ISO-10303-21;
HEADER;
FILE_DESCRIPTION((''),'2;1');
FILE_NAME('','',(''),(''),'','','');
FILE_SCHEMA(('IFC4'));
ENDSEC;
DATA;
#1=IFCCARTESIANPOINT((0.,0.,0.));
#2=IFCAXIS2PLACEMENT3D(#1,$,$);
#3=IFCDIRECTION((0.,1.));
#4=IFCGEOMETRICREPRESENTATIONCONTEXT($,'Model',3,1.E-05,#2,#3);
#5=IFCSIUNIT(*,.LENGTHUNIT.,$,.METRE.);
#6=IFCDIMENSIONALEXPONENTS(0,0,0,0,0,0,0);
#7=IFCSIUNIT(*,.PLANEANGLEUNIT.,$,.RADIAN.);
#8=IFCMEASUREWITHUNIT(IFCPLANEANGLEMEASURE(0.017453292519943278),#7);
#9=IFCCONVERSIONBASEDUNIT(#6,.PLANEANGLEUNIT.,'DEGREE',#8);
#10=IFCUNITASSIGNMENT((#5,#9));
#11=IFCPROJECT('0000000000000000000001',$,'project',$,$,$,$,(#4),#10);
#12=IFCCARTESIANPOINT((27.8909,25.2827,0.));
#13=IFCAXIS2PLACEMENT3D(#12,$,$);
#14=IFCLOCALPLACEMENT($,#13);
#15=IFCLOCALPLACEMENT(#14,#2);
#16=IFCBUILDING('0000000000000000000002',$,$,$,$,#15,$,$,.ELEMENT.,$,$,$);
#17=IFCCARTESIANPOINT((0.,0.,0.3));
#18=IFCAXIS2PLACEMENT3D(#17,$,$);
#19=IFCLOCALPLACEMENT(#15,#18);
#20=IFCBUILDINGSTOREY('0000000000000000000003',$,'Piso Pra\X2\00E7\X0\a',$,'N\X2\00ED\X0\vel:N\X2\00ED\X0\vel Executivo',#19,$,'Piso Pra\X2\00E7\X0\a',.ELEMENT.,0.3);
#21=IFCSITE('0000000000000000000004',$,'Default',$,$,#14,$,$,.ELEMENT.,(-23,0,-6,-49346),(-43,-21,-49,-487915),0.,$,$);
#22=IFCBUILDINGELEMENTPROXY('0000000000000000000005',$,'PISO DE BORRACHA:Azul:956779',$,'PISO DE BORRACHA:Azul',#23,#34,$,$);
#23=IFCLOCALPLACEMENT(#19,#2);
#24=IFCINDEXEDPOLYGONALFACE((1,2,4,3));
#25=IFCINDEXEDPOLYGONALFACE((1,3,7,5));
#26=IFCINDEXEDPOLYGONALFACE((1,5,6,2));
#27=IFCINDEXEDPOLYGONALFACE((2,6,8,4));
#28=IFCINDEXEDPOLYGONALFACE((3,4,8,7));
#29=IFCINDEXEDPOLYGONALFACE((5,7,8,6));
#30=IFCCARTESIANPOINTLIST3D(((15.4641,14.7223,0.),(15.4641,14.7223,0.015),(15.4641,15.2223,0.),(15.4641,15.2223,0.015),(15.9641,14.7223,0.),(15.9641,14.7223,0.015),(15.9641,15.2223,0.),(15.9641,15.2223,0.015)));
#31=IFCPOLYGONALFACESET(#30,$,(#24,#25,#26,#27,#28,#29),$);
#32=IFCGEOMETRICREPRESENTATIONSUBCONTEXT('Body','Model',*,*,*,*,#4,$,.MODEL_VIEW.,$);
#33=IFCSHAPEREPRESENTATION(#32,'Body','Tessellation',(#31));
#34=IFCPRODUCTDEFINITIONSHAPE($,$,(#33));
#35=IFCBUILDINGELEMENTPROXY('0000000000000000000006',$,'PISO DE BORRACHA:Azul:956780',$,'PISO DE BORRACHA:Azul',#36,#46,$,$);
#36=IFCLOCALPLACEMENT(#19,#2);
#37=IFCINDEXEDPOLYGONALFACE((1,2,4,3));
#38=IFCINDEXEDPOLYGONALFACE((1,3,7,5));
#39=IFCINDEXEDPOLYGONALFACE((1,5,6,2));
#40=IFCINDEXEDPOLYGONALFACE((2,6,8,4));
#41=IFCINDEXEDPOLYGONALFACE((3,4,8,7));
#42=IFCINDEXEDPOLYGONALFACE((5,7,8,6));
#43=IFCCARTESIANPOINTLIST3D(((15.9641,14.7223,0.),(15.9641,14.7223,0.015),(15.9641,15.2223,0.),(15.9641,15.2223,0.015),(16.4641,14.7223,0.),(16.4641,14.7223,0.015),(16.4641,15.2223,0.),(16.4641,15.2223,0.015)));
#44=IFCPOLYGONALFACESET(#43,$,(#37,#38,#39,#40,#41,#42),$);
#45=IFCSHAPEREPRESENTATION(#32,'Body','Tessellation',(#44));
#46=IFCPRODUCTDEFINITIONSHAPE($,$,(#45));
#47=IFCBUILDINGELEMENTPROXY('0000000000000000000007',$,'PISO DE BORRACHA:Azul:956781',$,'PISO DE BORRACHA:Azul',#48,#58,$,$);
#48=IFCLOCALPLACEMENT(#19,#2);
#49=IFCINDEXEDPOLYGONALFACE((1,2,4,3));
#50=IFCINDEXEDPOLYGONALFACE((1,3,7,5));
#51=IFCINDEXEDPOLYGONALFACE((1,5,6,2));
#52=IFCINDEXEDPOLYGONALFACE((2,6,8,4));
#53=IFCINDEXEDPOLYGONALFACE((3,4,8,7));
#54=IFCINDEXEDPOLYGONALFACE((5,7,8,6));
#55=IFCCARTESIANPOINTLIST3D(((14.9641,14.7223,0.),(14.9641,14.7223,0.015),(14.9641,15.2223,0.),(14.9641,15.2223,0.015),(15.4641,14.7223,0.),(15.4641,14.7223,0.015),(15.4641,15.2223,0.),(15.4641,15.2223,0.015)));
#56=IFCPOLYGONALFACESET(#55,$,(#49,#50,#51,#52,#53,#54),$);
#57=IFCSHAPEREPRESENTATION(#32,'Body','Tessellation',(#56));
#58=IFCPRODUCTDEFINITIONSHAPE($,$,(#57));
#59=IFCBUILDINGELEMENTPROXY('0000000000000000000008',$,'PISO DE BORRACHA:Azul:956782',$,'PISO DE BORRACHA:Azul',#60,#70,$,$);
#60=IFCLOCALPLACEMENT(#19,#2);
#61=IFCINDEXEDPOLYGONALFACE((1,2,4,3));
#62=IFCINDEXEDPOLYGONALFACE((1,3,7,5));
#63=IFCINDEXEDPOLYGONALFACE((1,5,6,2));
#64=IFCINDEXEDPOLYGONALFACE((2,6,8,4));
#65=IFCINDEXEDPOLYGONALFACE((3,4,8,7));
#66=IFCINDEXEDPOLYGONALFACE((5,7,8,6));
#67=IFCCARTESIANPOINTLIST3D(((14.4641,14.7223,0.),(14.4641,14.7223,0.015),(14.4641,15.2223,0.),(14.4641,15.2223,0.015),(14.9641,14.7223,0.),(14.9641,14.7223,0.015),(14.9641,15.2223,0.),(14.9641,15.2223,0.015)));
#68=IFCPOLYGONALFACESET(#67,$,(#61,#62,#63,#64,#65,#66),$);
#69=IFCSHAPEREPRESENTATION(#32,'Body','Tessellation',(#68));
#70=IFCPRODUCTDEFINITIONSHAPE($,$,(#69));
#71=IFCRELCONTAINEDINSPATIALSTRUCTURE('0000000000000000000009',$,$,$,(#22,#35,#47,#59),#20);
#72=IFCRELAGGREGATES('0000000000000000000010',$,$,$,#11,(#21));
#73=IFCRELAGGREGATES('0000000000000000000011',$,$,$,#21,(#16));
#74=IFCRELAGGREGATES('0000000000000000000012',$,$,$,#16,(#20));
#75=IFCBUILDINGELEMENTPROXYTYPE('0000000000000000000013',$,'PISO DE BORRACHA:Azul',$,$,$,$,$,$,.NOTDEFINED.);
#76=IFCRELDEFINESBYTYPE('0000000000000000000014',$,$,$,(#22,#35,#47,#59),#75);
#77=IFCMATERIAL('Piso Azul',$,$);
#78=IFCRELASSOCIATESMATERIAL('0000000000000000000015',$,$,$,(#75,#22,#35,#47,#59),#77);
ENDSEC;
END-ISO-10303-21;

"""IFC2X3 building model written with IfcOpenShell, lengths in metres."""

from ifc_helpers import new_model, entity, si_unit, converted_unit, direction, frame, origin, origin_2d_with_axis, place, context, subcontext, project, spatial, rectangle, extrude, source, transform, mapped, material, type_object, type_shapes, element, save


model = new_model("IFC2X3")

# Units and contexts
model_context = context("Model", 3, precision=1e-05, world=origin(), true_north=direction((0.0, 1.0)))
body_context = subcontext(model_context, "Body", "Model", "MODEL_VIEW")
ifc_project = project(units=[si_unit("LENGTHUNIT", "METRE"), converted_unit("PLANEANGLEUNIT", "DEGREE", entity("IfcPlaneAngleMeasure", 0.017453292519943278), si_unit("PLANEANGLEUNIT", "RADIAN"), dimensions=[0, 0, 0, 0, 0, 0, 0])], contexts=[model_context])

# Site, building, storey
site_placement = place(None, frame((27.8909, 25.2827, 0.0)))
site = spatial("IfcSite", under=ifc_project, at=site_placement, Name="Default", CompositionType="ELEMENT", RefLatitude=(-23, 0, -6, -49346), RefLongitude=(-43, -21, -49, -487915), RefElevation=0.0)
building_placement = place(site_placement, origin())
building = spatial("IfcBuilding", under=site, at=building_placement, CompositionType="ELEMENT")
storey_placement = place(building_placement, frame((0.0, 0.0, 0.3)))
storey = spatial("IfcBuildingStorey", under=building, at=storey_placement, Name="Piso Praça", ObjectType="Nível:Nível Executivo", LongName="Piso Praça", CompositionType="ELEMENT", Elevation=0.3)

# Building element proxies
ifc_material_1 = material(Name="Piso Azul")
building_element_proxy_type_1 = type_object("IfcBuildingElementProxyType", Name="PISO DE BORRACHA:Azul", PredefinedType="NOTDEFINED", material=ifc_material_1)
shared_shape_1 = source(origin(), body_context, "Body", "SweptSolid", [
    extrude(rectangle(XDim=0.5, YDim=0.5, at=origin_2d_with_axis()), frame((0.25, 0.25, 0.0), z_axis=(0.0, 0.0, 1.0), x_axis=(-1.0, 0.0, 0.0)), (0.0, 0.0, 1.0), 0.015),
])
type_shapes(building_element_proxy_type_1, [shared_shape_1])
for number, where, name in (
    (1, (15.4641, 14.7223, 0.0), "PISO DE BORRACHA:Azul:956779"),
    (2, (15.9641, 14.7223, 0.0), "PISO DE BORRACHA:Azul:956780"),
    (3, (14.9641, 14.7223, 0.0), "PISO DE BORRACHA:Azul:956781"),
    (4, (14.4641, 14.7223, 0.0), "PISO DE BORRACHA:Azul:956782"),
):
    element("IfcBuildingElementProxy", number, at=place(storey_placement, frame(where)), inside=storey, type_object=building_element_proxy_type_1, material=ifc_material_1, Name=name, ObjectType="PISO DE BORRACHA:Azul", context=body_context, shape_type="MappedRepresentation", body=[
        mapped(shared_shape_1, transform((0.0, 0.0, 0.0), scale=1.0)),
    ])

save(model, "model.ifc")
